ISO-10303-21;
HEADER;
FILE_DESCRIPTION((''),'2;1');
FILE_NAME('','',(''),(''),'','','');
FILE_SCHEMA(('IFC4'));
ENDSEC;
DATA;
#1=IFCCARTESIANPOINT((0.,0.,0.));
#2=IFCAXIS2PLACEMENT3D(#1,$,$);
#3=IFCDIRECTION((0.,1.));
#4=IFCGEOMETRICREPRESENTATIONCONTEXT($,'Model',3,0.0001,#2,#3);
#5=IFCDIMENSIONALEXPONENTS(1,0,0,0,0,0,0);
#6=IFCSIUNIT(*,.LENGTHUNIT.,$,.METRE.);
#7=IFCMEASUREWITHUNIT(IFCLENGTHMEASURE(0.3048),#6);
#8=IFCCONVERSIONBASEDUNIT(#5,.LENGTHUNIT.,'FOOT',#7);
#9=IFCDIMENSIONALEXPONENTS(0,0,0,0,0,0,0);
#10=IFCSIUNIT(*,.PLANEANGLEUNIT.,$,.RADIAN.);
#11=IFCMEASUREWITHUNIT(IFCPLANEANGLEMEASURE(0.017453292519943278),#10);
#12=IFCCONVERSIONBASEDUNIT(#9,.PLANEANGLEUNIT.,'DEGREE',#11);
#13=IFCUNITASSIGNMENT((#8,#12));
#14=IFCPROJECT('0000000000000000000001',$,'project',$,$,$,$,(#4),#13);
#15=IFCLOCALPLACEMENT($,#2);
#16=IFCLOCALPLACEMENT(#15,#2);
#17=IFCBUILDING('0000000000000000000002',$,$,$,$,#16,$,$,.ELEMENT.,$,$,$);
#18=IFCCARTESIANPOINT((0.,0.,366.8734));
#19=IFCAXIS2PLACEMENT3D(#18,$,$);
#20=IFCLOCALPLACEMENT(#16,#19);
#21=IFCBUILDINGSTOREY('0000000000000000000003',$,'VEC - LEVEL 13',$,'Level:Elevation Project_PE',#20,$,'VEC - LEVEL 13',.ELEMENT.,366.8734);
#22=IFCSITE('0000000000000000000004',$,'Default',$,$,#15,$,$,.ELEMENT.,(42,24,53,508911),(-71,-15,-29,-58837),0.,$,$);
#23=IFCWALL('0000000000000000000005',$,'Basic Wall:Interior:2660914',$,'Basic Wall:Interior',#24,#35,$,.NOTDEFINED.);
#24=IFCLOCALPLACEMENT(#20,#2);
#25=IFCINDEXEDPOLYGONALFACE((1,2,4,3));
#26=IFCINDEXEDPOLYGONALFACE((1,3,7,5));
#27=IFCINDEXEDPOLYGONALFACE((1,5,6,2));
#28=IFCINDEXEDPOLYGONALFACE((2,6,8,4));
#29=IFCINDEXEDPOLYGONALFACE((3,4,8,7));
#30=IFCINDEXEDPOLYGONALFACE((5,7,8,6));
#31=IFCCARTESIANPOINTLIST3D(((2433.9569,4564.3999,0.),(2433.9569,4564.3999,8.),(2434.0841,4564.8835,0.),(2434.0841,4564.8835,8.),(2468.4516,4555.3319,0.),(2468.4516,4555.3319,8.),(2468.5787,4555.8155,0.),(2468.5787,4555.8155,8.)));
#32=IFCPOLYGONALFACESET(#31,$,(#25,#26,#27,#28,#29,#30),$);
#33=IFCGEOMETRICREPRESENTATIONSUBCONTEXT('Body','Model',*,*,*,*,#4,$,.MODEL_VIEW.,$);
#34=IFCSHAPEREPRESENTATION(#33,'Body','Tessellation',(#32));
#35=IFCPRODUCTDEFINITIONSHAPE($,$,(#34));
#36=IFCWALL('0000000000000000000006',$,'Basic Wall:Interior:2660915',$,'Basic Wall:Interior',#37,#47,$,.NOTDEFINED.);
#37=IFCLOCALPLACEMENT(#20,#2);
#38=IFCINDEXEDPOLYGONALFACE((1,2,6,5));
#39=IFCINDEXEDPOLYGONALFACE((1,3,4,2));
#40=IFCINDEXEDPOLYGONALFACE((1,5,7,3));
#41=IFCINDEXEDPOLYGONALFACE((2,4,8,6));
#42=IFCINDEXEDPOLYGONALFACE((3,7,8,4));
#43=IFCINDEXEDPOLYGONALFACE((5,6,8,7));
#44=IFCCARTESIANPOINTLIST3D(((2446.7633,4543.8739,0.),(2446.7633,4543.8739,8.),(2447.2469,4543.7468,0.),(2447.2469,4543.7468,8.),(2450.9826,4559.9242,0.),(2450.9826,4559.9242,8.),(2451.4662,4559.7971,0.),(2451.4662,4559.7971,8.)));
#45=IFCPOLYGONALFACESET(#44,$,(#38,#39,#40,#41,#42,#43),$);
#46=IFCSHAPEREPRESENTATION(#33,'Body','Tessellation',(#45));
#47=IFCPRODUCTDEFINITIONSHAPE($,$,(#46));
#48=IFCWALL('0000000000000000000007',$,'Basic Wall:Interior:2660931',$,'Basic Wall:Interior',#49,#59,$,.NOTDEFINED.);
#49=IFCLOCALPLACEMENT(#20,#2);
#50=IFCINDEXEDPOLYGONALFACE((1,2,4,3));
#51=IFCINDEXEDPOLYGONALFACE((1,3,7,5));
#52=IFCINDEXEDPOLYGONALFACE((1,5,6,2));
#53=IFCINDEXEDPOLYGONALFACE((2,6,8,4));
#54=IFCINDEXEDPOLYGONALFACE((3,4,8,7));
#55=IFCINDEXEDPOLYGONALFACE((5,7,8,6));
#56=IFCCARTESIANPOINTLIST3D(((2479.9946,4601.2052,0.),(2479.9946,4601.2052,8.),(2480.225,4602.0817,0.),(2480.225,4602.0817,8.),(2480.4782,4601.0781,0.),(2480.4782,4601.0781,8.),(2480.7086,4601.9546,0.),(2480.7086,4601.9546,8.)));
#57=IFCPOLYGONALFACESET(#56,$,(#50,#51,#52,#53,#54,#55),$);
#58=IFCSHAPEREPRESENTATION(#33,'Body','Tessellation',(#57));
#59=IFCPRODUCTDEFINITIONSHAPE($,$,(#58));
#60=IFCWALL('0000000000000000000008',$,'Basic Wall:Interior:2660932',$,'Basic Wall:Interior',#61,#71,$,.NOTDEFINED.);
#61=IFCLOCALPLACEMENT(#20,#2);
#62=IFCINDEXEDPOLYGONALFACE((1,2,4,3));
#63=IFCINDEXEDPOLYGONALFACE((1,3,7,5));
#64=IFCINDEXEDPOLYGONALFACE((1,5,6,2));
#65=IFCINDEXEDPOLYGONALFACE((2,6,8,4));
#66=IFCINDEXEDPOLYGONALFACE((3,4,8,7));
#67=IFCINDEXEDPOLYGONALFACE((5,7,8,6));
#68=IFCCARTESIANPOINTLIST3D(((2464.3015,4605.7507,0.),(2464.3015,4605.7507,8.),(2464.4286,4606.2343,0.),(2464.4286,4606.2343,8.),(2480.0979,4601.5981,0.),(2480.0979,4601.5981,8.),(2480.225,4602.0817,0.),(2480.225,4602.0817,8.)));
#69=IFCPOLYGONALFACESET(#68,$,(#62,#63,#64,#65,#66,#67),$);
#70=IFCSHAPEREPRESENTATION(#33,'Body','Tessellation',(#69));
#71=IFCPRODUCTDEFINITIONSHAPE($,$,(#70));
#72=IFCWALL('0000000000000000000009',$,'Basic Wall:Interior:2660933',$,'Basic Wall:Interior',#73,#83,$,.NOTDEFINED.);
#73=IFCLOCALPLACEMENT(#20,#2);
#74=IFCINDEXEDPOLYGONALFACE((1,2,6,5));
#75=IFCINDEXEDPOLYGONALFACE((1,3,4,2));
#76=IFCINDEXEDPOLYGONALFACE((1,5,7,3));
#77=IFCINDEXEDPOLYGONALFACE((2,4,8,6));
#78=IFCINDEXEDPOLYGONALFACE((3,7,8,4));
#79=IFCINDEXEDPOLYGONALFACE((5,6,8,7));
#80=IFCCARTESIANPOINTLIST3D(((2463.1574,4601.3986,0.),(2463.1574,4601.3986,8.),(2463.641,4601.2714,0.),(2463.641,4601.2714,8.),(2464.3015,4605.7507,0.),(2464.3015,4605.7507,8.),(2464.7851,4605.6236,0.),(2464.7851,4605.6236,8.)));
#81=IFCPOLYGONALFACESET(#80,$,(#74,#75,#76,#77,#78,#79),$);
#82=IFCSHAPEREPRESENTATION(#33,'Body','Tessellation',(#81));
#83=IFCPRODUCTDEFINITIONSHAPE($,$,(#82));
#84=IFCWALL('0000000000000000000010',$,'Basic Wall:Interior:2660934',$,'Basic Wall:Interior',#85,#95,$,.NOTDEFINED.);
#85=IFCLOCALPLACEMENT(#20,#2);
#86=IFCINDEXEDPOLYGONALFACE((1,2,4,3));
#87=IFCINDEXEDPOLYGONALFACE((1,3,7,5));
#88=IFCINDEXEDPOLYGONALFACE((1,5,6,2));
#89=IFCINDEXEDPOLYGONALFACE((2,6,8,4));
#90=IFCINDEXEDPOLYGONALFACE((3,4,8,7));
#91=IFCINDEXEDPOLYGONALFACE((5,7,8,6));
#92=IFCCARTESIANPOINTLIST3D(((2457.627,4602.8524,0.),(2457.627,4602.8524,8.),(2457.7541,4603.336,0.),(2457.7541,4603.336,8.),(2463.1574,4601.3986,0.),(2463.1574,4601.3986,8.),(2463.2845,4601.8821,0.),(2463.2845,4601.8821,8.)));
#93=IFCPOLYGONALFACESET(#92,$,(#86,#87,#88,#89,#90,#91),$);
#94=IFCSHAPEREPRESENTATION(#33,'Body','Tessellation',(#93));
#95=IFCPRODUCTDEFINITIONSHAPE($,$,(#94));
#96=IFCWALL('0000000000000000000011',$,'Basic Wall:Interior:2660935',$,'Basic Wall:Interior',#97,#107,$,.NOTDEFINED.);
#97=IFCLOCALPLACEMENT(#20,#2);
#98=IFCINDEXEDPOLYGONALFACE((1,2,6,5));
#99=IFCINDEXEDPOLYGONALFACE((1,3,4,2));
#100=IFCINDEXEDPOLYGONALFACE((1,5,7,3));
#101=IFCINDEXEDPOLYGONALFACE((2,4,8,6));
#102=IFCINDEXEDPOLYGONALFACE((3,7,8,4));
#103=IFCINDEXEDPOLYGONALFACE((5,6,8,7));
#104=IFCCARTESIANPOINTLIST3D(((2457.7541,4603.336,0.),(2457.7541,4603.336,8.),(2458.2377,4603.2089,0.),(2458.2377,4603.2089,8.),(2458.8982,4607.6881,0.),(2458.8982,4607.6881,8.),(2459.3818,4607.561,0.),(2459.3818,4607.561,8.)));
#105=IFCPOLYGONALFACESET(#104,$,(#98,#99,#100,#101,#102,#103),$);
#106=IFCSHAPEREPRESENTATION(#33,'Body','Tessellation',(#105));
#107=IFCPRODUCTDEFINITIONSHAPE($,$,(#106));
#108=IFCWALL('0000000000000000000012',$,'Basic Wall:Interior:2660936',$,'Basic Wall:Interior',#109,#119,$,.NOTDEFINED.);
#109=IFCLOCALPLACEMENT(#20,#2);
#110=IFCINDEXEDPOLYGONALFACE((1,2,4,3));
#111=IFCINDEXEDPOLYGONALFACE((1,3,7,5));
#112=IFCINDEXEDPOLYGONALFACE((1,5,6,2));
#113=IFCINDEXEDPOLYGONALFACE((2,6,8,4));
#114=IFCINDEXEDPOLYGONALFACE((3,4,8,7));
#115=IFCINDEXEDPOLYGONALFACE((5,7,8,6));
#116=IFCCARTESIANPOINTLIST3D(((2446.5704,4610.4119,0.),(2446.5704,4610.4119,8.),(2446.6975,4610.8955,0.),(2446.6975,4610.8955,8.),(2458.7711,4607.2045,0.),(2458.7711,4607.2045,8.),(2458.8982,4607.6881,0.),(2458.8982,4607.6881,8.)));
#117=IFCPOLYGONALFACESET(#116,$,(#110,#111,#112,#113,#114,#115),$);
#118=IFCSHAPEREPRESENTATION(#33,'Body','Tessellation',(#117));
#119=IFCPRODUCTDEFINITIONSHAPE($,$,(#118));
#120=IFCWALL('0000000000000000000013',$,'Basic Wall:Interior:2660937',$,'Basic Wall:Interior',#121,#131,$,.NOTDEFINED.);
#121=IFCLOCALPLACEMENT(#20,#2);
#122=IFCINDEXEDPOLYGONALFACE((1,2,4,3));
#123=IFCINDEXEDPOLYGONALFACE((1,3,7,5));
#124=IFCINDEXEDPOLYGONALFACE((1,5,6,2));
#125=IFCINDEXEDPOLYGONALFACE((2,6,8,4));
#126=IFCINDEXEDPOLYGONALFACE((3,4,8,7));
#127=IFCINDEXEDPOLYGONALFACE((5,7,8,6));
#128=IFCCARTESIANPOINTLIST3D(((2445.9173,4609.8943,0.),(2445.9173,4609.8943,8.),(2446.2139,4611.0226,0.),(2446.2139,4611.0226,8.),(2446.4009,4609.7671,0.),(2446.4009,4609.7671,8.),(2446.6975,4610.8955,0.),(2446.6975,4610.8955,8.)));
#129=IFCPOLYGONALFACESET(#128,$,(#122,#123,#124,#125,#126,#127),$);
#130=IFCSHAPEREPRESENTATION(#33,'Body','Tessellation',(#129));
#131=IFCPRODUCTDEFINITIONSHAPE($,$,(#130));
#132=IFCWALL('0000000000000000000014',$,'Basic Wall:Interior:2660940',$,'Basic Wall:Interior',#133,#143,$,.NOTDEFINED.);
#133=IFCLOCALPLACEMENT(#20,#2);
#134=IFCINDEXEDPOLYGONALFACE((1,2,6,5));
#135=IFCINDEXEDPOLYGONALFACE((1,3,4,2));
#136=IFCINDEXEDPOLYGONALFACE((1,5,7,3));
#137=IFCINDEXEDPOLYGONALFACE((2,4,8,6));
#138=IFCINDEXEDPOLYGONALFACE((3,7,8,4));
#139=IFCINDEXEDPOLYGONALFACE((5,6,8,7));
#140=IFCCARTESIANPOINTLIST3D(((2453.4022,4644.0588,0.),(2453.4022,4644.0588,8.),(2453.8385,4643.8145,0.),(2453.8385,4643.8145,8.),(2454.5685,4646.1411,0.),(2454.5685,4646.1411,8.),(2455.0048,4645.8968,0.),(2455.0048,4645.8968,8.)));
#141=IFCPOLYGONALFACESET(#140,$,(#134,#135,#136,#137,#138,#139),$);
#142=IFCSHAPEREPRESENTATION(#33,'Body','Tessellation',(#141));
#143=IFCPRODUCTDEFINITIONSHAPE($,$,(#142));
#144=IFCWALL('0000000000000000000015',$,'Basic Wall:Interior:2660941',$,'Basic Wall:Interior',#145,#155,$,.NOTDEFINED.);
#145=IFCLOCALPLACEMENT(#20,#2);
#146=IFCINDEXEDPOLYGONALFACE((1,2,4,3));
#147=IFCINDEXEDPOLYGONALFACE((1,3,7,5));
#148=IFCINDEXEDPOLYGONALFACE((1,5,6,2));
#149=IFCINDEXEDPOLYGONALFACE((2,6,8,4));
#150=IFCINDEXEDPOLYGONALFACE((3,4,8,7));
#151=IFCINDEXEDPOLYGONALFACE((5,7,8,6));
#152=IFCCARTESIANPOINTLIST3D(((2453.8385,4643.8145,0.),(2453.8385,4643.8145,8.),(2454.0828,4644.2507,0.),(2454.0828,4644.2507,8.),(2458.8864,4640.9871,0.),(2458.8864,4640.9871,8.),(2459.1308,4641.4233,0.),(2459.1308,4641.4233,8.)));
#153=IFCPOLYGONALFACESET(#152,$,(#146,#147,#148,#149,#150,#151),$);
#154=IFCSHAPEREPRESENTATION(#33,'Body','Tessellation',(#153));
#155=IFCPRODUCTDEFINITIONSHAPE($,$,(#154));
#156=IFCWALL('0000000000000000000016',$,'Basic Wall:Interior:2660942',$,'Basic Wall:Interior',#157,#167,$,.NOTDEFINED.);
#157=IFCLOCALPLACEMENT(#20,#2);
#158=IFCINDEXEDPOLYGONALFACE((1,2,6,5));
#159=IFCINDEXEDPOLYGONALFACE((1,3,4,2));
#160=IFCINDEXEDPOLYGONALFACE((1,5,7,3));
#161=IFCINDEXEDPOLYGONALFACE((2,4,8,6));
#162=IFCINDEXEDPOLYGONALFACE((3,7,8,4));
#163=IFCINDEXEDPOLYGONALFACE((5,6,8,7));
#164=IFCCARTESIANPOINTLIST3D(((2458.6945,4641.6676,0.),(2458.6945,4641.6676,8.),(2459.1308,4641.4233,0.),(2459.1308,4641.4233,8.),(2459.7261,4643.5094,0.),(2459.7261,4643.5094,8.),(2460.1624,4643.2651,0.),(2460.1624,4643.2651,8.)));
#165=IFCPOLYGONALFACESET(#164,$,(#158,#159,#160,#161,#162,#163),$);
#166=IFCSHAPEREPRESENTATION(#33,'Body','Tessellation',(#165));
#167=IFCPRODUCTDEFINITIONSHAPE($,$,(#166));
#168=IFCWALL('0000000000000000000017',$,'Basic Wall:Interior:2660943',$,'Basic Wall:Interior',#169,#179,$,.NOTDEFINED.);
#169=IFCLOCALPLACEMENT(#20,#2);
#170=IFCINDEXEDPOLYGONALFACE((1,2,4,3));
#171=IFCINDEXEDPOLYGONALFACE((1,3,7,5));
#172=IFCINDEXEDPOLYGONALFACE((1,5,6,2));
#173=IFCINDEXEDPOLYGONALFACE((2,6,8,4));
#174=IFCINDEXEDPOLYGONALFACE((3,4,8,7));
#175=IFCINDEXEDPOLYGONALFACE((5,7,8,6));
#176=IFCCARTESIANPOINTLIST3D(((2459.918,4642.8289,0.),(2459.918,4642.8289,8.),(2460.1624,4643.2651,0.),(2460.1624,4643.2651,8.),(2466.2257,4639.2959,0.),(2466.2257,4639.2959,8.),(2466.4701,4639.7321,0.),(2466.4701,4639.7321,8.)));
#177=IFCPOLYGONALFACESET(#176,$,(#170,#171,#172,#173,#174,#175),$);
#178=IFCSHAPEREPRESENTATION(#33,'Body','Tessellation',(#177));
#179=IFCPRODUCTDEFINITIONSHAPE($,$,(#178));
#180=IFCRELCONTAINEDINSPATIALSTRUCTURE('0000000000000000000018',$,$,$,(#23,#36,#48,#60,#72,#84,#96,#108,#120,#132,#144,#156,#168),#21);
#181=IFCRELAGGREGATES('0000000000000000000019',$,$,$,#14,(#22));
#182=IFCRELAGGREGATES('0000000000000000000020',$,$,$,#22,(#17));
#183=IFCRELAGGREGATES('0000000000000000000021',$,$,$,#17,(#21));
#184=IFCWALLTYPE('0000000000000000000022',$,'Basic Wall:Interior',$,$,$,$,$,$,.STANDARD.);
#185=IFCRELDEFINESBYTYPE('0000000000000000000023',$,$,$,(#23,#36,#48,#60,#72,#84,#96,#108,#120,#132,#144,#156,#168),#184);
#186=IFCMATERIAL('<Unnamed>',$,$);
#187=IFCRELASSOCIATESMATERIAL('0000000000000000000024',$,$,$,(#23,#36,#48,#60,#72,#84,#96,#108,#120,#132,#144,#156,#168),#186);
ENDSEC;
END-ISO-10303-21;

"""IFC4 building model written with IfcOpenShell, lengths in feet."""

from ifc_helpers import new_model, entity, si_unit, converted_unit, direction, frame, origin, place, context, subcontext, project, spatial, indexed_curve, outline, extrude, material, type_object, element, save


model = new_model("IFC4")

# Units and contexts
model_context = context("Model", 3, precision=0.0001, world=origin(), true_north=direction((0.0, 1.0)))
body_context = subcontext(model_context, "Body", "Model", "MODEL_VIEW")
ifc_project = project(units=[converted_unit("LENGTHUNIT", "FOOT", entity("IfcLengthMeasure", 0.3048), si_unit("LENGTHUNIT", "METRE"), dimensions=[1, 0, 0, 0, 0, 0, 0]), converted_unit("PLANEANGLEUNIT", "DEGREE", entity("IfcPlaneAngleMeasure", 0.017453292519943278), si_unit("PLANEANGLEUNIT", "RADIAN"), dimensions=[0, 0, 0, 0, 0, 0, 0])], contexts=[model_context])

# Site, building, storey
site_placement = place(None, origin())
site = spatial("IfcSite", under=ifc_project, at=site_placement, Name="Default", CompositionType="ELEMENT", RefLatitude=(42, 24, 53, 508911), RefLongitude=(-71, -15, -29, -58837), RefElevation=0.0)
building_placement = place(site_placement, origin())
building = spatial("IfcBuilding", under=site, at=building_placement, CompositionType="ELEMENT")
storey_placement = place(building_placement, frame((0.0, 0.0, 366.8734)))
storey = spatial("IfcBuildingStorey", under=building, at=storey_placement, Name="VEC - LEVEL 13", ObjectType="Level:Elevation Project_PE", LongName="VEC - LEVEL 13", CompositionType="ELEMENT", Elevation=366.8734)

# Walls
ifc_material_1 = material(Name="<Unnamed>")
wall_type = type_object("IfcWallType", Name="Basic Wall:Interior", PredefinedType="STANDARD")
wall_1_placement = place(storey_placement, frame((2434.0205, 4564.6417, 0.0), z_axis=(0.0, 0.0, 1.0), x_axis=(0.96714, -0.254244, 0.0)))
element("IfcWall", 1, at=wall_1_placement, inside=storey, type_object=wall_type, material=ifc_material_1, Name="Basic Wall:Interior:2660914", ObjectType="Basic Wall:Interior", PredefinedType="NOTDEFINED", context=body_context, shape_type="SweptSolid", body=[
    extrude(outline(indexed_curve([(35.6667, 0.25), (0.0, 0.25), (0.0, -0.25), (35.6667, -0.25), (35.6667, 0.25)], self_intersect=False)), origin(), (0.0, 0.0, 1.0), 8.0),
])
wall_2_placement = place(storey_placement, frame((2451.2244, 4559.8606, 0.0), z_axis=(0.0, 0.0, 1.0), x_axis=(-0.254244, -0.96714, 0.0)))
element("IfcWall", 2, at=wall_2_placement, inside=storey, type_object=wall_type, material=ifc_material_1, Name="Basic Wall:Interior:2660915", ObjectType="Basic Wall:Interior", PredefinedType="NOTDEFINED", context=body_context, shape_type="SweptSolid", body=[
    extrude(outline(indexed_curve([(16.5956, 0.25), (0.0, 0.25), (0.0, -0.25), (16.5956, -0.25), (16.5956, 0.25)], self_intersect=False)), origin(), (0.0, 0.0, 1.0), 8.0),
])
wall_3_placement = place(storey_placement, frame((2480.2364, 4601.1416, 0.0), z_axis=(0.0, 0.0, 1.0), x_axis=(0.254244, 0.96714, 0.0)))
element("IfcWall", 3, at=wall_3_placement, inside=storey, type_object=wall_type, material=ifc_material_1, Name="Basic Wall:Interior:2660931", ObjectType="Basic Wall:Interior", PredefinedType="NOTDEFINED", context=body_context, shape_type="SweptSolid", body=[
    extrude(outline(indexed_curve([(0.9062, 0.25), (0.0, 0.25), (0.0, -0.25), (0.9062, -0.25), (0.9062, 0.25)], self_intersect=False)), origin(), (0.0, 0.0, 1.0), 8.0),
])
wall_4_placement = place(storey_placement, frame((2480.1615, 4601.8399, 0.0), z_axis=(0.0, 0.0, 1.0), x_axis=(-0.96714, 0.254244, 0.0)))
element("IfcWall", 4, at=wall_4_placement, inside=storey, type_object=wall_type, material=ifc_material_1, Name="Basic Wall:Interior:2660932", ObjectType="Basic Wall:Interior", PredefinedType="NOTDEFINED", context=body_context, shape_type="SweptSolid", body=[
    extrude(outline(indexed_curve([(16.3331, 0.25), (0.0, 0.25), (0.0, -0.25), (16.3331, -0.25), (16.3331, 0.25)], self_intersect=False)), origin(), (0.0, 0.0, 1.0), 8.0),
])
wall_5_placement = place(storey_placement, frame((2464.5433, 4605.6871, 0.0), z_axis=(0.0, 0.0, 1.0), x_axis=(-0.254244, -0.96714, 0.0)))
element("IfcWall", 5, at=wall_5_placement, inside=storey, type_object=wall_type, material=ifc_material_1, Name="Basic Wall:Interior:2660933", ObjectType="Basic Wall:Interior", PredefinedType="NOTDEFINED", context=body_context, shape_type="SweptSolid", body=[
    extrude(outline(indexed_curve([(4.5, 0.25), (0.0, 0.25), (0.0, -0.25), (4.5, -0.25), (4.5, 0.25)], self_intersect=False)), origin(), (0.0, 0.0, 1.0), 8.0),
])
wall_6_placement = place(storey_placement, frame((2463.221, 4601.6404, 0.0), z_axis=(0.0, 0.0, 1.0), x_axis=(-0.96714, 0.254244, 0.0)))
element("IfcWall", 6, at=wall_6_placement, inside=storey, type_object=wall_type, material=ifc_material_1, Name="Basic Wall:Interior:2660934", ObjectType="Basic Wall:Interior", PredefinedType="NOTDEFINED", context=body_context, shape_type="SweptSolid", body=[
    extrude(outline(indexed_curve([(5.7183, 0.25), (0.0, 0.25), (0.0, -0.25), (5.7183, -0.25), (5.7183, 0.25)], self_intersect=False)), origin(), (0.0, 0.0, 1.0), 8.0),
])
wall_7_placement = place(storey_placement, frame((2457.9959, 4603.2724, 0.0), z_axis=(0.0, 0.0, 1.0), x_axis=(0.254244, 0.96714, 0.0)))
element("IfcWall", 7, at=wall_7_placement, inside=storey, type_object=wall_type, material=ifc_material_1, Name="Basic Wall:Interior:2660935", ObjectType="Basic Wall:Interior", PredefinedType="NOTDEFINED", context=body_context, shape_type="SweptSolid", body=[
    extrude(outline(indexed_curve([(4.5, 0.25), (0.0, 0.25), (0.0, -0.25), (4.5, -0.25), (4.5, 0.25)], self_intersect=False)), origin(), (0.0, 0.0, 1.0), 8.0),
])
wall_8_placement = place(storey_placement, frame((2458.8347, 4607.4463, 0.0), z_axis=(0.0, 0.0, 1.0), x_axis=(-0.96714, 0.254244, 0.0)))
element("IfcWall", 8, at=wall_8_placement, inside=storey, type_object=wall_type, material=ifc_material_1, Name="Basic Wall:Interior:2660936", ObjectType="Basic Wall:Interior", PredefinedType="NOTDEFINED", context=body_context, shape_type="SweptSolid", body=[
    extrude(outline(indexed_curve([(12.6153, 0.25), (0.0, 0.25), (0.0, -0.25), (12.6153, -0.25), (12.6153, 0.25)], self_intersect=False)), origin(), (0.0, 0.0, 1.0), 8.0),
])
wall_9_placement = place(storey_placement, frame((2446.4557, 4610.959, 0.0), z_axis=(0.0, 0.0, 1.0), x_axis=(-0.254244, -0.96714, 0.0)))
element("IfcWall", 9, at=wall_9_placement, inside=storey, type_object=wall_type, material=ifc_material_1, Name="Basic Wall:Interior:2660937", ObjectType="Basic Wall:Interior", PredefinedType="NOTDEFINED", context=body_context, shape_type="SweptSolid", body=[
    extrude(outline(indexed_curve([(1.1667, 0.25), (0.0, 0.25), (0.0, -0.25), (1.1667, -0.25), (1.1667, 0.25)], self_intersect=False)), origin(), (0.0, 0.0, 1.0), 8.0),
])
wall_10_placement = place(storey_placement, frame((2454.7866, 4646.0189, 0.0), z_axis=(0.0, 0.0, 1.0), x_axis=(-0.488675, -0.872466, 0.0)))
element("IfcWall", 10, at=wall_10_placement, inside=storey, type_object=wall_type, material=ifc_material_1, Name="Basic Wall:Interior:2660940", ObjectType="Basic Wall:Interior", PredefinedType="NOTDEFINED", context=body_context, shape_type="SweptSolid", body=[
    extrude(outline(indexed_curve([(2.3867, 0.25), (0.0, 0.25), (0.0, -0.25), (2.3867, -0.25), (2.3867, 0.25)], self_intersect=False)), origin(), (0.0, 0.0, 1.0), 8.0),
])
wall_11_placement = place(storey_placement, frame((2453.9606, 4644.0326, 0.0), z_axis=(0.0, 0.0, 1.0), x_axis=(0.872466, -0.488675, 0.0)))
element("IfcWall", 11, at=wall_11_placement, inside=storey, type_object=wall_type, material=ifc_material_1, Name="Basic Wall:Interior:2660941", ObjectType="Basic Wall:Interior", PredefinedType="NOTDEFINED", context=body_context, shape_type="SweptSolid", body=[
    extrude(outline(indexed_curve([(5.7859, 0.25), (0.0, 0.25), (0.0, -0.25), (5.7859, -0.25), (5.7859, 0.25)], self_intersect=False)), origin(), (0.0, 0.0, 1.0), 8.0),
])
wall_12_placement = place(storey_placement, frame((2458.9126, 4641.5455, 0.0), z_axis=(0.0, 0.0, 1.0), x_axis=(0.488675, 0.872466, 0.0)))
element("IfcWall", 12, at=wall_12_placement, inside=storey, type_object=wall_type, material=ifc_material_1, Name="Basic Wall:Interior:2660942", ObjectType="Basic Wall:Interior", PredefinedType="NOTDEFINED", context=body_context, shape_type="SweptSolid", body=[
    extrude(outline(indexed_curve([(2.111, 0.25), (0.0, 0.25), (0.0, -0.25), (2.111, -0.25), (2.111, 0.25)], self_intersect=False)), origin(), (0.0, 0.0, 1.0), 8.0),
])
wall_13_placement = place(storey_placement, frame((2460.0402, 4643.047, 0.0), z_axis=(0.0, 0.0, 1.0), x_axis=(0.872466, -0.488675, 0.0)))
element("IfcWall", 13, at=wall_13_placement, inside=storey, type_object=wall_type, material=ifc_material_1, Name="Basic Wall:Interior:2660943", ObjectType="Basic Wall:Interior", PredefinedType="NOTDEFINED", context=body_context, shape_type="SweptSolid", body=[
    extrude(outline(indexed_curve([(7.2297, 0.25), (0.0, 0.25), (0.0, -0.25), (7.2297, -0.25), (7.2297, 0.25)], self_intersect=False)), origin(), (0.0, 0.0, 1.0), 8.0),
])

save(model, "model.ifc")
